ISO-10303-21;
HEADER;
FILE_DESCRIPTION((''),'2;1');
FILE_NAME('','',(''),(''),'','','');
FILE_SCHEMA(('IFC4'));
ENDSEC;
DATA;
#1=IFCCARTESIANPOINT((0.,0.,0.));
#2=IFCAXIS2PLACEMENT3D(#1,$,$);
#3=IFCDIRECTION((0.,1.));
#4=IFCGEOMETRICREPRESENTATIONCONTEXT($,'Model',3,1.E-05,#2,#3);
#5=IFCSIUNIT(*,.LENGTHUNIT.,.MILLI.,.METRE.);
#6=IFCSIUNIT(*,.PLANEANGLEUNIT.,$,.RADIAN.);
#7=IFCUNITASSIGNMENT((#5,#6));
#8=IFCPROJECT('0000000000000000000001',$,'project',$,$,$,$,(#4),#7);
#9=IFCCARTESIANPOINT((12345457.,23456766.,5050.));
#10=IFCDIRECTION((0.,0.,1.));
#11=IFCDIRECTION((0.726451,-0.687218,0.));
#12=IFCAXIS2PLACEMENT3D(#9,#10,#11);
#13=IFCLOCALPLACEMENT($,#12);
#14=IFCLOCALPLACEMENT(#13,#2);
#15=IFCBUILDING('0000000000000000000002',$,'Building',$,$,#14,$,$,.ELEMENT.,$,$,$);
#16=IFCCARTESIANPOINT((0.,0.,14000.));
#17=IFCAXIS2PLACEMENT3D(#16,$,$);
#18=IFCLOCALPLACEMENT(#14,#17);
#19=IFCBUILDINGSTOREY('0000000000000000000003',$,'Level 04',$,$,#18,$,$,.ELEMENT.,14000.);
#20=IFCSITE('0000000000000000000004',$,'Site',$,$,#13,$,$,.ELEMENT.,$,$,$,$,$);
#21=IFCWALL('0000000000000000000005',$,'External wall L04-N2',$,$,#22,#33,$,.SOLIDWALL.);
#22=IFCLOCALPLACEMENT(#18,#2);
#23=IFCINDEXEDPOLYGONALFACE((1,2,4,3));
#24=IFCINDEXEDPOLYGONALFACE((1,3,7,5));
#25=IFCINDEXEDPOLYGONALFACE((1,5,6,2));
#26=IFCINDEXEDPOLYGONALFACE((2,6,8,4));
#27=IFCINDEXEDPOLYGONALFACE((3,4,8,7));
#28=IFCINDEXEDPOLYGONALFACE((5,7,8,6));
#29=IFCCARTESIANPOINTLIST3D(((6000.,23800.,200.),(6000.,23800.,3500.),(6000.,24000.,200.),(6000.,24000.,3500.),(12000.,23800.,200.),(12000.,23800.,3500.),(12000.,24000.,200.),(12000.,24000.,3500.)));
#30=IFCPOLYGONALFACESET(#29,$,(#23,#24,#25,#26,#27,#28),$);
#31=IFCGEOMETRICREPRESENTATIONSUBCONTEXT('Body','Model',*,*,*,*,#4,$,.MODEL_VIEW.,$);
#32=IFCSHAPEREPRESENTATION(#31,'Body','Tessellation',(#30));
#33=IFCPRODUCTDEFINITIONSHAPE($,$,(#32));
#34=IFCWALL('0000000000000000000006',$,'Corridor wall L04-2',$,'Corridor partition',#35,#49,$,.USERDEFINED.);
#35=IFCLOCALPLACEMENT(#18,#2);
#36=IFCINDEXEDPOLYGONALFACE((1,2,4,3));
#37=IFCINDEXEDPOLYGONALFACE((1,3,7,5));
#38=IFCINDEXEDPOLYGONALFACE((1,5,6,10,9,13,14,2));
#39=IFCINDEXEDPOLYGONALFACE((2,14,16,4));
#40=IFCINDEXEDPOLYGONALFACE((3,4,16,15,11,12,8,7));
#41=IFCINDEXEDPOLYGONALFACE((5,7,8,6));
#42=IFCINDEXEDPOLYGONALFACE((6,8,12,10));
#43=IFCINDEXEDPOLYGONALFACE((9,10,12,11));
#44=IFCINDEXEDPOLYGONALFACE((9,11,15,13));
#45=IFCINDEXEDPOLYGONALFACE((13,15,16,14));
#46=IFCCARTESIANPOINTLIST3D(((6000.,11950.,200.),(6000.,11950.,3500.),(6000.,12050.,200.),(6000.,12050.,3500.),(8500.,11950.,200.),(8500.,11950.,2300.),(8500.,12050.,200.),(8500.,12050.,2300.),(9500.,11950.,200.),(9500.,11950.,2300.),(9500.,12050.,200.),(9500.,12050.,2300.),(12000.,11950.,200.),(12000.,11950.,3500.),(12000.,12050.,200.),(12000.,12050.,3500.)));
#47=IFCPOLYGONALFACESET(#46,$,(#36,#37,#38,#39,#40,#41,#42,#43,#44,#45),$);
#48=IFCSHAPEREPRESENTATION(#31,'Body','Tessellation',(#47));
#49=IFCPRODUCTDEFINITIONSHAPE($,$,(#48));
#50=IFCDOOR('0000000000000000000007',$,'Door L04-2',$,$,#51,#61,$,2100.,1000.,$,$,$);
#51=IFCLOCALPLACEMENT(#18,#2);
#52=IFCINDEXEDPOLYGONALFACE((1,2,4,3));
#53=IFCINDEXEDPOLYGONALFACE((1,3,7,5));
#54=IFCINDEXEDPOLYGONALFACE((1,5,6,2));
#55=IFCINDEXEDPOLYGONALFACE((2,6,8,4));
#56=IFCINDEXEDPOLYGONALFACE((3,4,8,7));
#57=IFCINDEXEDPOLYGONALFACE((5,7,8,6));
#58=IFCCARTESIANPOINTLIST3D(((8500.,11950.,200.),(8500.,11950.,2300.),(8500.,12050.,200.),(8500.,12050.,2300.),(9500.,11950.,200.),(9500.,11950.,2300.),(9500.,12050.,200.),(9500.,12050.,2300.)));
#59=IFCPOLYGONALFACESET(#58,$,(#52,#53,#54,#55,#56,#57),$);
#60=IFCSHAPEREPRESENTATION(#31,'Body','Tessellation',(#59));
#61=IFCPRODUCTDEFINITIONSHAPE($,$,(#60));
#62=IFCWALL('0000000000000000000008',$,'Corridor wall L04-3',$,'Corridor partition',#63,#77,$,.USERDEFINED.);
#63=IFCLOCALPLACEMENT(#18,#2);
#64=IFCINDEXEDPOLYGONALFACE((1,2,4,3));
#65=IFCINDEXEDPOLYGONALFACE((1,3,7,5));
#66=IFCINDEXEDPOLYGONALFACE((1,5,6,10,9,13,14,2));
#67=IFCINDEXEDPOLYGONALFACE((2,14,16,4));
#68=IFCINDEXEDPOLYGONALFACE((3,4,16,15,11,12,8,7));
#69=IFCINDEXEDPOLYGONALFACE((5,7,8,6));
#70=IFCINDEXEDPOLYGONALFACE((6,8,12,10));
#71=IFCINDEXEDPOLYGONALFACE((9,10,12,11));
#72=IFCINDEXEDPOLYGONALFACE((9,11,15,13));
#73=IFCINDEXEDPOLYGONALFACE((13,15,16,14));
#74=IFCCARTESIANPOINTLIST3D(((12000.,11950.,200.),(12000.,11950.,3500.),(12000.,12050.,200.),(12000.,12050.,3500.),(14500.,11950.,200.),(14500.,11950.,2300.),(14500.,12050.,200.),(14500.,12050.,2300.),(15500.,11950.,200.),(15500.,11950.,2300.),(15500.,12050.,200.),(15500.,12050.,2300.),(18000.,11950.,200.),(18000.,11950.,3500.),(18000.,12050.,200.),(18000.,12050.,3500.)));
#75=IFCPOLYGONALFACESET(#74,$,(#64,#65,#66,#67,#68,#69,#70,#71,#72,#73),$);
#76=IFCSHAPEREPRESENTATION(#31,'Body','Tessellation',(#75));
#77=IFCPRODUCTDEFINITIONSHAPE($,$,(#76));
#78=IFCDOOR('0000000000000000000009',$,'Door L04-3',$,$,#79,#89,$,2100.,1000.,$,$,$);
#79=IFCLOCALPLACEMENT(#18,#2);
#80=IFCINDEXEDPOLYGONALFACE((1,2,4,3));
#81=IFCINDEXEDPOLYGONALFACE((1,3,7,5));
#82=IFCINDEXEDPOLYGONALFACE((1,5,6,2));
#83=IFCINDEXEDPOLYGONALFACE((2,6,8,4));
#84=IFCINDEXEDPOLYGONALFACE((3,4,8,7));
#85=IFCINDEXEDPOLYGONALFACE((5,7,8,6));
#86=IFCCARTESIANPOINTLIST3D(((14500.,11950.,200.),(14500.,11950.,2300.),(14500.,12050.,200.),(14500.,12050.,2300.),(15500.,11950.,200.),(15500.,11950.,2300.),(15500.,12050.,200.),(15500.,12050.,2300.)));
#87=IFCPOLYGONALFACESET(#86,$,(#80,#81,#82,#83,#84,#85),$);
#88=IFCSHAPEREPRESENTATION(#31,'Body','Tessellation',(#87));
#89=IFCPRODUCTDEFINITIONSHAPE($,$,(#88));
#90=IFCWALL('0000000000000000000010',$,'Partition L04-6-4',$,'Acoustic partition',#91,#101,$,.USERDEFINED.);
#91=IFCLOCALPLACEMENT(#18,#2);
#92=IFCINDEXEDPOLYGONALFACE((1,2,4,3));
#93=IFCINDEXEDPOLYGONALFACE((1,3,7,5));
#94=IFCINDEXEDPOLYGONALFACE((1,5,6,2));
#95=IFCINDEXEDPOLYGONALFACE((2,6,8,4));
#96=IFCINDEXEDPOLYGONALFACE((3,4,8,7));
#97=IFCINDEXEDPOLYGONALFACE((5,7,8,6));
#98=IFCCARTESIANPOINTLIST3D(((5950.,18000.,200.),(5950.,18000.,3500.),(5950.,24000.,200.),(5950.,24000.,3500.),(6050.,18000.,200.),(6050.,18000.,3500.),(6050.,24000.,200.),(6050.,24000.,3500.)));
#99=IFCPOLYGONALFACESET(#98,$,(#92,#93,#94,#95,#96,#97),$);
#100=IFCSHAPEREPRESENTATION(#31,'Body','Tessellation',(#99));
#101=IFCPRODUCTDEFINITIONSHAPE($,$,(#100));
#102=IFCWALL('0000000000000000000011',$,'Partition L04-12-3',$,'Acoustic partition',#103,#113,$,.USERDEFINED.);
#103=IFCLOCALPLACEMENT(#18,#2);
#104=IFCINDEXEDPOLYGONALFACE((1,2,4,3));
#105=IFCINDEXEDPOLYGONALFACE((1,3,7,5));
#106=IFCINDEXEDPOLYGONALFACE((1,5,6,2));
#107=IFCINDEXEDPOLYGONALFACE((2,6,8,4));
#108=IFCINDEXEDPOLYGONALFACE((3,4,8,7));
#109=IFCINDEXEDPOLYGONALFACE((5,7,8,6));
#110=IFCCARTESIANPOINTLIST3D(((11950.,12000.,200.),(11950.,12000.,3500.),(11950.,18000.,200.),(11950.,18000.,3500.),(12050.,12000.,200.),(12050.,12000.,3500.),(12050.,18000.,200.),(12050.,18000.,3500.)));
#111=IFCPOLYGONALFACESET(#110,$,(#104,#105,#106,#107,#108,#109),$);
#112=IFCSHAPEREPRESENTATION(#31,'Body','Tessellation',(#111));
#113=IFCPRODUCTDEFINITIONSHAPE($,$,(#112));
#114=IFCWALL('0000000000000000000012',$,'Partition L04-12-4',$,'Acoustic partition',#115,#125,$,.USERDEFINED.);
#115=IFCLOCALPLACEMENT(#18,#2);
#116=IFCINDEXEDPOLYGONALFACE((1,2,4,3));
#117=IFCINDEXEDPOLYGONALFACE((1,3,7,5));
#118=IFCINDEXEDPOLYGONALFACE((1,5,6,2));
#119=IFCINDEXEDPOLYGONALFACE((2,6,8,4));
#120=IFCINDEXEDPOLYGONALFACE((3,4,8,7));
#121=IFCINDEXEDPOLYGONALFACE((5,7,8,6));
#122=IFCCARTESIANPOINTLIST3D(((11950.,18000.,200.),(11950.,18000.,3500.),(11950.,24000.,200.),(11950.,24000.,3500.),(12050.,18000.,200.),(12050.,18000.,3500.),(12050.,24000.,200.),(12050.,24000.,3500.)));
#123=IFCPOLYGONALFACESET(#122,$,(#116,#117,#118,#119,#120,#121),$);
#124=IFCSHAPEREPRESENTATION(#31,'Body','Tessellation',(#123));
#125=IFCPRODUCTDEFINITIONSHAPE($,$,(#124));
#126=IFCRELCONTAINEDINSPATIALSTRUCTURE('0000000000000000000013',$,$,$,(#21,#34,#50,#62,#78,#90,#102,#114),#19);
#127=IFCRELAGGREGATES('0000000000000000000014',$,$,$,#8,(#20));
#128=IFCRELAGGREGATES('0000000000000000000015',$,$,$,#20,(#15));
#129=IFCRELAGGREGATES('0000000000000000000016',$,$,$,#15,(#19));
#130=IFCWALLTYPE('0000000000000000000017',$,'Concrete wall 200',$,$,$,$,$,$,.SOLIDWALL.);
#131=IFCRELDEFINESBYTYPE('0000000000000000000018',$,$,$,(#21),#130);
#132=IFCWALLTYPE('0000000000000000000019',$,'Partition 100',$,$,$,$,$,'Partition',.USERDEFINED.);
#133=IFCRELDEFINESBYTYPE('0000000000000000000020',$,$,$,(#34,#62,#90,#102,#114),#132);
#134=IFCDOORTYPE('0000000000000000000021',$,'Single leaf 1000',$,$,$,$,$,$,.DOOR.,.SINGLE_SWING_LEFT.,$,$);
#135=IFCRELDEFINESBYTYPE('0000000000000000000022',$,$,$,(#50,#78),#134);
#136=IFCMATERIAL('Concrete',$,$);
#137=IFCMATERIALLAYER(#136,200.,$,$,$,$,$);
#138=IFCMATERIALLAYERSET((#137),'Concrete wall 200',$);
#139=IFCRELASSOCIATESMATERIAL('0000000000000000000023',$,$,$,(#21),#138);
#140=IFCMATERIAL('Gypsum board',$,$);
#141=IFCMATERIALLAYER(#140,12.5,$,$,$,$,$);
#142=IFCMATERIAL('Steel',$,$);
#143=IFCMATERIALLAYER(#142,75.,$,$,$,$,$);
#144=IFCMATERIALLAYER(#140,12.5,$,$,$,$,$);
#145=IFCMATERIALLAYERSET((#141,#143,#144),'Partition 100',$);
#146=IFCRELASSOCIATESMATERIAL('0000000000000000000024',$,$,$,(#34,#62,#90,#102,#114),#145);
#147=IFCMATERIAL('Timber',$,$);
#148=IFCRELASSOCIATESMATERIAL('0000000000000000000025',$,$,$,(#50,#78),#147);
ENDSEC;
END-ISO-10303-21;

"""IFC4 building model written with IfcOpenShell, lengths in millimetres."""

from ifc_helpers import new_model, si_unit, direction, frame, origin, place, context, subcontext, project, spatial, rectangle, extrude, source, transform, mapped, material, layer, layer_set, layer_usage, type_object, type_shapes, element, fill, save


model = new_model("IFC4")

# Units and contexts
model_context = context("Model", 3, precision=1e-05, world=origin(), true_north=direction((0.0, 1.0)))
body_context = subcontext(model_context, "Body", "Model", "MODEL_VIEW")
ifc_project = project(units=[si_unit("LENGTHUNIT", "METRE", prefix="MILLI"), si_unit("PLANEANGLEUNIT", "RADIAN")], contexts=[model_context])

# Site, building, storey
site_placement = place(None, frame((12345457.0, 23456766.0, 5050.0), z_axis=(0.0, 0.0, 1.0), x_axis=(0.726451, -0.687218, 0.0)))
site = spatial("IfcSite", under=ifc_project, at=site_placement, Name="Site", CompositionType="ELEMENT")
building_placement = place(site_placement, origin())
building = spatial("IfcBuilding", under=site, at=building_placement, Name="Building", CompositionType="ELEMENT")
storey_placement = place(building_placement, frame((0.0, 0.0, 14000.0)))
storey = spatial("IfcBuildingStorey", under=building, at=storey_placement, Name="Level 04", CompositionType="ELEMENT", Elevation=14000.0)

# Shared definitions
ifc_material_1 = material(Name="Steel")

# Shared definitions
ifc_material_2 = material(Name="Concrete")

# Wall
ifc_layer_1 = layer(ifc_material_2, 200.0)
ifc_layer_set_1 = layer_set([ifc_layer_1], Name="Concrete wall 200")
ifc_layer_usage_1 = layer_usage(ifc_layer_set_1, "AXIS2", "POSITIVE", 0.0)
wall_type_1 = type_object("IfcWallType", Name="Concrete wall 200", PredefinedType="SOLIDWALL")
for number, where, name in (
    (1, (6000.0, 23800.0, 200.0), "External wall L04-N2"),
):
    element("IfcWall", number, at=place(storey_placement, frame(where)), inside=storey, type_object=wall_type_1, material=ifc_layer_usage_1, Name=name, PredefinedType="SOLIDWALL", context=body_context, shape_type="SweptSolid", body=[
        extrude(rectangle(XDim=6000.0, YDim=200.0), frame((3000.0, 100.0, 0.0)), (0.0, 0.0, 1.0), 3300.0),
    ])

# Walls, openings, doors
ifc_material_3 = material(Name="Gypsum board")
ifc_layer_2 = layer(ifc_material_3, 12.5)
ifc_layer_3 = layer(ifc_material_1, 75.0)
ifc_layer_4 = layer(ifc_material_3, 12.5)
ifc_layer_set_2 = layer_set([ifc_layer_2, ifc_layer_3, ifc_layer_4], Name="Partition 100")
ifc_layer_usage_2 = layer_usage(ifc_layer_set_2, "AXIS2", "POSITIVE", 0.0)
wall_type_2 = type_object("IfcWallType", Name="Partition 100", ElementType="Partition", PredefinedType="USERDEFINED")
wall_1_placement = place(storey_placement, frame((6000.0, 11950.0, 200.0)))
wall_1 = element("IfcWall", 2, at=wall_1_placement, inside=storey, type_object=wall_type_2, material=ifc_layer_usage_2, Name="Corridor wall L04-2", ObjectType="Corridor partition", PredefinedType="USERDEFINED", context=body_context, shape_type="SweptSolid", body=[
    extrude(rectangle(XDim=6000.0, YDim=100.0), frame((3000.0, 50.0, 0.0)), (0.0, 0.0, 1.0), 3300.0),
])
opening_1_placement = place(wall_1_placement, frame((2500.0, -50.0, 0.0)))
opening_1 = element("IfcOpeningElement", 3, at=opening_1_placement, cuts=wall_1, PredefinedType="OPENING", context=body_context, shape_type="SweptSolid", body=[
    extrude(rectangle(XDim=1000.0, YDim=200.0), frame((500.0, 100.0, 0.0)), (0.0, 0.0, 1.0), 2100.0),
])
ifc_material_4 = material(Name="Timber")
door_type = type_object("IfcDoorType", Name="Single leaf 1000", OperationType="SINGLE_SWING_LEFT", PredefinedType="DOOR")
shared_shape = source(origin(), body_context, "Body", "SweptSolid", [
    extrude(rectangle(XDim=1000.0, YDim=100.0), frame((500.0, 50.0, 0.0)), (0.0, 0.0, 1.0), 2100.0),
])
type_shapes(door_type, [shared_shape])
door_1_placement = place(storey_placement, frame((8500.0, 11950.0, 200.0)))
door_1 = element("IfcDoor", 4, at=door_1_placement, inside=storey, type_object=door_type, material=ifc_material_4, Name="Door L04-2", OverallHeight=2100.0, OverallWidth=1000.0, context=body_context, shape_type="MappedRepresentation", body=[
    mapped(shared_shape, transform((0.0, 0.0, 0.0))),
])
fill(opening_1, door_1)
wall_2_placement = place(storey_placement, frame((12000.0, 11950.0, 200.0)))
wall_2 = element("IfcWall", 5, at=wall_2_placement, inside=storey, type_object=wall_type_2, material=ifc_layer_usage_2, Name="Corridor wall L04-3", ObjectType="Corridor partition", PredefinedType="USERDEFINED", context=body_context, shape_type="SweptSolid", body=[
    extrude(rectangle(XDim=6000.0, YDim=100.0), frame((3000.0, 50.0, 0.0)), (0.0, 0.0, 1.0), 3300.0),
])
opening_2_placement = place(wall_2_placement, frame((2500.0, -50.0, 0.0)))
opening_2 = element("IfcOpeningElement", 6, at=opening_2_placement, cuts=wall_2, PredefinedType="OPENING", context=body_context, shape_type="SweptSolid", body=[
    extrude(rectangle(XDim=1000.0, YDim=200.0), frame((500.0, 100.0, 0.0)), (0.0, 0.0, 1.0), 2100.0),
])
door_2_placement = place(storey_placement, frame((14500.0, 11950.0, 200.0)))
door_2 = element("IfcDoor", 7, at=door_2_placement, inside=storey, type_object=door_type, material=ifc_material_4, Name="Door L04-3", OverallHeight=2100.0, OverallWidth=1000.0, context=body_context, shape_type="MappedRepresentation", body=[
    mapped(shared_shape, transform((0.0, 0.0, 0.0))),
])
fill(opening_2, door_2)

# Walls
for number, where, name in (
    (8, (5950.0, 18000.0, 200.0), "Partition L04-6-4"),
    (9, (11950.0, 12000.0, 200.0), "Partition L04-12-3"),
    (10, (11950.0, 18000.0, 200.0), "Partition L04-12-4"),
):
    element("IfcWall", number, at=place(storey_placement, frame(where)), inside=storey, type_object=wall_type_2, material=ifc_layer_usage_2, Name=name, ObjectType="Acoustic partition", PredefinedType="USERDEFINED", context=body_context, shape_type="SweptSolid", body=[
        extrude(rectangle(XDim=100.0, YDim=6000.0), frame((50.0, 3000.0, 0.0)), (0.0, 0.0, 1.0), 3300.0),
    ])

save(model, "model.ifc")
